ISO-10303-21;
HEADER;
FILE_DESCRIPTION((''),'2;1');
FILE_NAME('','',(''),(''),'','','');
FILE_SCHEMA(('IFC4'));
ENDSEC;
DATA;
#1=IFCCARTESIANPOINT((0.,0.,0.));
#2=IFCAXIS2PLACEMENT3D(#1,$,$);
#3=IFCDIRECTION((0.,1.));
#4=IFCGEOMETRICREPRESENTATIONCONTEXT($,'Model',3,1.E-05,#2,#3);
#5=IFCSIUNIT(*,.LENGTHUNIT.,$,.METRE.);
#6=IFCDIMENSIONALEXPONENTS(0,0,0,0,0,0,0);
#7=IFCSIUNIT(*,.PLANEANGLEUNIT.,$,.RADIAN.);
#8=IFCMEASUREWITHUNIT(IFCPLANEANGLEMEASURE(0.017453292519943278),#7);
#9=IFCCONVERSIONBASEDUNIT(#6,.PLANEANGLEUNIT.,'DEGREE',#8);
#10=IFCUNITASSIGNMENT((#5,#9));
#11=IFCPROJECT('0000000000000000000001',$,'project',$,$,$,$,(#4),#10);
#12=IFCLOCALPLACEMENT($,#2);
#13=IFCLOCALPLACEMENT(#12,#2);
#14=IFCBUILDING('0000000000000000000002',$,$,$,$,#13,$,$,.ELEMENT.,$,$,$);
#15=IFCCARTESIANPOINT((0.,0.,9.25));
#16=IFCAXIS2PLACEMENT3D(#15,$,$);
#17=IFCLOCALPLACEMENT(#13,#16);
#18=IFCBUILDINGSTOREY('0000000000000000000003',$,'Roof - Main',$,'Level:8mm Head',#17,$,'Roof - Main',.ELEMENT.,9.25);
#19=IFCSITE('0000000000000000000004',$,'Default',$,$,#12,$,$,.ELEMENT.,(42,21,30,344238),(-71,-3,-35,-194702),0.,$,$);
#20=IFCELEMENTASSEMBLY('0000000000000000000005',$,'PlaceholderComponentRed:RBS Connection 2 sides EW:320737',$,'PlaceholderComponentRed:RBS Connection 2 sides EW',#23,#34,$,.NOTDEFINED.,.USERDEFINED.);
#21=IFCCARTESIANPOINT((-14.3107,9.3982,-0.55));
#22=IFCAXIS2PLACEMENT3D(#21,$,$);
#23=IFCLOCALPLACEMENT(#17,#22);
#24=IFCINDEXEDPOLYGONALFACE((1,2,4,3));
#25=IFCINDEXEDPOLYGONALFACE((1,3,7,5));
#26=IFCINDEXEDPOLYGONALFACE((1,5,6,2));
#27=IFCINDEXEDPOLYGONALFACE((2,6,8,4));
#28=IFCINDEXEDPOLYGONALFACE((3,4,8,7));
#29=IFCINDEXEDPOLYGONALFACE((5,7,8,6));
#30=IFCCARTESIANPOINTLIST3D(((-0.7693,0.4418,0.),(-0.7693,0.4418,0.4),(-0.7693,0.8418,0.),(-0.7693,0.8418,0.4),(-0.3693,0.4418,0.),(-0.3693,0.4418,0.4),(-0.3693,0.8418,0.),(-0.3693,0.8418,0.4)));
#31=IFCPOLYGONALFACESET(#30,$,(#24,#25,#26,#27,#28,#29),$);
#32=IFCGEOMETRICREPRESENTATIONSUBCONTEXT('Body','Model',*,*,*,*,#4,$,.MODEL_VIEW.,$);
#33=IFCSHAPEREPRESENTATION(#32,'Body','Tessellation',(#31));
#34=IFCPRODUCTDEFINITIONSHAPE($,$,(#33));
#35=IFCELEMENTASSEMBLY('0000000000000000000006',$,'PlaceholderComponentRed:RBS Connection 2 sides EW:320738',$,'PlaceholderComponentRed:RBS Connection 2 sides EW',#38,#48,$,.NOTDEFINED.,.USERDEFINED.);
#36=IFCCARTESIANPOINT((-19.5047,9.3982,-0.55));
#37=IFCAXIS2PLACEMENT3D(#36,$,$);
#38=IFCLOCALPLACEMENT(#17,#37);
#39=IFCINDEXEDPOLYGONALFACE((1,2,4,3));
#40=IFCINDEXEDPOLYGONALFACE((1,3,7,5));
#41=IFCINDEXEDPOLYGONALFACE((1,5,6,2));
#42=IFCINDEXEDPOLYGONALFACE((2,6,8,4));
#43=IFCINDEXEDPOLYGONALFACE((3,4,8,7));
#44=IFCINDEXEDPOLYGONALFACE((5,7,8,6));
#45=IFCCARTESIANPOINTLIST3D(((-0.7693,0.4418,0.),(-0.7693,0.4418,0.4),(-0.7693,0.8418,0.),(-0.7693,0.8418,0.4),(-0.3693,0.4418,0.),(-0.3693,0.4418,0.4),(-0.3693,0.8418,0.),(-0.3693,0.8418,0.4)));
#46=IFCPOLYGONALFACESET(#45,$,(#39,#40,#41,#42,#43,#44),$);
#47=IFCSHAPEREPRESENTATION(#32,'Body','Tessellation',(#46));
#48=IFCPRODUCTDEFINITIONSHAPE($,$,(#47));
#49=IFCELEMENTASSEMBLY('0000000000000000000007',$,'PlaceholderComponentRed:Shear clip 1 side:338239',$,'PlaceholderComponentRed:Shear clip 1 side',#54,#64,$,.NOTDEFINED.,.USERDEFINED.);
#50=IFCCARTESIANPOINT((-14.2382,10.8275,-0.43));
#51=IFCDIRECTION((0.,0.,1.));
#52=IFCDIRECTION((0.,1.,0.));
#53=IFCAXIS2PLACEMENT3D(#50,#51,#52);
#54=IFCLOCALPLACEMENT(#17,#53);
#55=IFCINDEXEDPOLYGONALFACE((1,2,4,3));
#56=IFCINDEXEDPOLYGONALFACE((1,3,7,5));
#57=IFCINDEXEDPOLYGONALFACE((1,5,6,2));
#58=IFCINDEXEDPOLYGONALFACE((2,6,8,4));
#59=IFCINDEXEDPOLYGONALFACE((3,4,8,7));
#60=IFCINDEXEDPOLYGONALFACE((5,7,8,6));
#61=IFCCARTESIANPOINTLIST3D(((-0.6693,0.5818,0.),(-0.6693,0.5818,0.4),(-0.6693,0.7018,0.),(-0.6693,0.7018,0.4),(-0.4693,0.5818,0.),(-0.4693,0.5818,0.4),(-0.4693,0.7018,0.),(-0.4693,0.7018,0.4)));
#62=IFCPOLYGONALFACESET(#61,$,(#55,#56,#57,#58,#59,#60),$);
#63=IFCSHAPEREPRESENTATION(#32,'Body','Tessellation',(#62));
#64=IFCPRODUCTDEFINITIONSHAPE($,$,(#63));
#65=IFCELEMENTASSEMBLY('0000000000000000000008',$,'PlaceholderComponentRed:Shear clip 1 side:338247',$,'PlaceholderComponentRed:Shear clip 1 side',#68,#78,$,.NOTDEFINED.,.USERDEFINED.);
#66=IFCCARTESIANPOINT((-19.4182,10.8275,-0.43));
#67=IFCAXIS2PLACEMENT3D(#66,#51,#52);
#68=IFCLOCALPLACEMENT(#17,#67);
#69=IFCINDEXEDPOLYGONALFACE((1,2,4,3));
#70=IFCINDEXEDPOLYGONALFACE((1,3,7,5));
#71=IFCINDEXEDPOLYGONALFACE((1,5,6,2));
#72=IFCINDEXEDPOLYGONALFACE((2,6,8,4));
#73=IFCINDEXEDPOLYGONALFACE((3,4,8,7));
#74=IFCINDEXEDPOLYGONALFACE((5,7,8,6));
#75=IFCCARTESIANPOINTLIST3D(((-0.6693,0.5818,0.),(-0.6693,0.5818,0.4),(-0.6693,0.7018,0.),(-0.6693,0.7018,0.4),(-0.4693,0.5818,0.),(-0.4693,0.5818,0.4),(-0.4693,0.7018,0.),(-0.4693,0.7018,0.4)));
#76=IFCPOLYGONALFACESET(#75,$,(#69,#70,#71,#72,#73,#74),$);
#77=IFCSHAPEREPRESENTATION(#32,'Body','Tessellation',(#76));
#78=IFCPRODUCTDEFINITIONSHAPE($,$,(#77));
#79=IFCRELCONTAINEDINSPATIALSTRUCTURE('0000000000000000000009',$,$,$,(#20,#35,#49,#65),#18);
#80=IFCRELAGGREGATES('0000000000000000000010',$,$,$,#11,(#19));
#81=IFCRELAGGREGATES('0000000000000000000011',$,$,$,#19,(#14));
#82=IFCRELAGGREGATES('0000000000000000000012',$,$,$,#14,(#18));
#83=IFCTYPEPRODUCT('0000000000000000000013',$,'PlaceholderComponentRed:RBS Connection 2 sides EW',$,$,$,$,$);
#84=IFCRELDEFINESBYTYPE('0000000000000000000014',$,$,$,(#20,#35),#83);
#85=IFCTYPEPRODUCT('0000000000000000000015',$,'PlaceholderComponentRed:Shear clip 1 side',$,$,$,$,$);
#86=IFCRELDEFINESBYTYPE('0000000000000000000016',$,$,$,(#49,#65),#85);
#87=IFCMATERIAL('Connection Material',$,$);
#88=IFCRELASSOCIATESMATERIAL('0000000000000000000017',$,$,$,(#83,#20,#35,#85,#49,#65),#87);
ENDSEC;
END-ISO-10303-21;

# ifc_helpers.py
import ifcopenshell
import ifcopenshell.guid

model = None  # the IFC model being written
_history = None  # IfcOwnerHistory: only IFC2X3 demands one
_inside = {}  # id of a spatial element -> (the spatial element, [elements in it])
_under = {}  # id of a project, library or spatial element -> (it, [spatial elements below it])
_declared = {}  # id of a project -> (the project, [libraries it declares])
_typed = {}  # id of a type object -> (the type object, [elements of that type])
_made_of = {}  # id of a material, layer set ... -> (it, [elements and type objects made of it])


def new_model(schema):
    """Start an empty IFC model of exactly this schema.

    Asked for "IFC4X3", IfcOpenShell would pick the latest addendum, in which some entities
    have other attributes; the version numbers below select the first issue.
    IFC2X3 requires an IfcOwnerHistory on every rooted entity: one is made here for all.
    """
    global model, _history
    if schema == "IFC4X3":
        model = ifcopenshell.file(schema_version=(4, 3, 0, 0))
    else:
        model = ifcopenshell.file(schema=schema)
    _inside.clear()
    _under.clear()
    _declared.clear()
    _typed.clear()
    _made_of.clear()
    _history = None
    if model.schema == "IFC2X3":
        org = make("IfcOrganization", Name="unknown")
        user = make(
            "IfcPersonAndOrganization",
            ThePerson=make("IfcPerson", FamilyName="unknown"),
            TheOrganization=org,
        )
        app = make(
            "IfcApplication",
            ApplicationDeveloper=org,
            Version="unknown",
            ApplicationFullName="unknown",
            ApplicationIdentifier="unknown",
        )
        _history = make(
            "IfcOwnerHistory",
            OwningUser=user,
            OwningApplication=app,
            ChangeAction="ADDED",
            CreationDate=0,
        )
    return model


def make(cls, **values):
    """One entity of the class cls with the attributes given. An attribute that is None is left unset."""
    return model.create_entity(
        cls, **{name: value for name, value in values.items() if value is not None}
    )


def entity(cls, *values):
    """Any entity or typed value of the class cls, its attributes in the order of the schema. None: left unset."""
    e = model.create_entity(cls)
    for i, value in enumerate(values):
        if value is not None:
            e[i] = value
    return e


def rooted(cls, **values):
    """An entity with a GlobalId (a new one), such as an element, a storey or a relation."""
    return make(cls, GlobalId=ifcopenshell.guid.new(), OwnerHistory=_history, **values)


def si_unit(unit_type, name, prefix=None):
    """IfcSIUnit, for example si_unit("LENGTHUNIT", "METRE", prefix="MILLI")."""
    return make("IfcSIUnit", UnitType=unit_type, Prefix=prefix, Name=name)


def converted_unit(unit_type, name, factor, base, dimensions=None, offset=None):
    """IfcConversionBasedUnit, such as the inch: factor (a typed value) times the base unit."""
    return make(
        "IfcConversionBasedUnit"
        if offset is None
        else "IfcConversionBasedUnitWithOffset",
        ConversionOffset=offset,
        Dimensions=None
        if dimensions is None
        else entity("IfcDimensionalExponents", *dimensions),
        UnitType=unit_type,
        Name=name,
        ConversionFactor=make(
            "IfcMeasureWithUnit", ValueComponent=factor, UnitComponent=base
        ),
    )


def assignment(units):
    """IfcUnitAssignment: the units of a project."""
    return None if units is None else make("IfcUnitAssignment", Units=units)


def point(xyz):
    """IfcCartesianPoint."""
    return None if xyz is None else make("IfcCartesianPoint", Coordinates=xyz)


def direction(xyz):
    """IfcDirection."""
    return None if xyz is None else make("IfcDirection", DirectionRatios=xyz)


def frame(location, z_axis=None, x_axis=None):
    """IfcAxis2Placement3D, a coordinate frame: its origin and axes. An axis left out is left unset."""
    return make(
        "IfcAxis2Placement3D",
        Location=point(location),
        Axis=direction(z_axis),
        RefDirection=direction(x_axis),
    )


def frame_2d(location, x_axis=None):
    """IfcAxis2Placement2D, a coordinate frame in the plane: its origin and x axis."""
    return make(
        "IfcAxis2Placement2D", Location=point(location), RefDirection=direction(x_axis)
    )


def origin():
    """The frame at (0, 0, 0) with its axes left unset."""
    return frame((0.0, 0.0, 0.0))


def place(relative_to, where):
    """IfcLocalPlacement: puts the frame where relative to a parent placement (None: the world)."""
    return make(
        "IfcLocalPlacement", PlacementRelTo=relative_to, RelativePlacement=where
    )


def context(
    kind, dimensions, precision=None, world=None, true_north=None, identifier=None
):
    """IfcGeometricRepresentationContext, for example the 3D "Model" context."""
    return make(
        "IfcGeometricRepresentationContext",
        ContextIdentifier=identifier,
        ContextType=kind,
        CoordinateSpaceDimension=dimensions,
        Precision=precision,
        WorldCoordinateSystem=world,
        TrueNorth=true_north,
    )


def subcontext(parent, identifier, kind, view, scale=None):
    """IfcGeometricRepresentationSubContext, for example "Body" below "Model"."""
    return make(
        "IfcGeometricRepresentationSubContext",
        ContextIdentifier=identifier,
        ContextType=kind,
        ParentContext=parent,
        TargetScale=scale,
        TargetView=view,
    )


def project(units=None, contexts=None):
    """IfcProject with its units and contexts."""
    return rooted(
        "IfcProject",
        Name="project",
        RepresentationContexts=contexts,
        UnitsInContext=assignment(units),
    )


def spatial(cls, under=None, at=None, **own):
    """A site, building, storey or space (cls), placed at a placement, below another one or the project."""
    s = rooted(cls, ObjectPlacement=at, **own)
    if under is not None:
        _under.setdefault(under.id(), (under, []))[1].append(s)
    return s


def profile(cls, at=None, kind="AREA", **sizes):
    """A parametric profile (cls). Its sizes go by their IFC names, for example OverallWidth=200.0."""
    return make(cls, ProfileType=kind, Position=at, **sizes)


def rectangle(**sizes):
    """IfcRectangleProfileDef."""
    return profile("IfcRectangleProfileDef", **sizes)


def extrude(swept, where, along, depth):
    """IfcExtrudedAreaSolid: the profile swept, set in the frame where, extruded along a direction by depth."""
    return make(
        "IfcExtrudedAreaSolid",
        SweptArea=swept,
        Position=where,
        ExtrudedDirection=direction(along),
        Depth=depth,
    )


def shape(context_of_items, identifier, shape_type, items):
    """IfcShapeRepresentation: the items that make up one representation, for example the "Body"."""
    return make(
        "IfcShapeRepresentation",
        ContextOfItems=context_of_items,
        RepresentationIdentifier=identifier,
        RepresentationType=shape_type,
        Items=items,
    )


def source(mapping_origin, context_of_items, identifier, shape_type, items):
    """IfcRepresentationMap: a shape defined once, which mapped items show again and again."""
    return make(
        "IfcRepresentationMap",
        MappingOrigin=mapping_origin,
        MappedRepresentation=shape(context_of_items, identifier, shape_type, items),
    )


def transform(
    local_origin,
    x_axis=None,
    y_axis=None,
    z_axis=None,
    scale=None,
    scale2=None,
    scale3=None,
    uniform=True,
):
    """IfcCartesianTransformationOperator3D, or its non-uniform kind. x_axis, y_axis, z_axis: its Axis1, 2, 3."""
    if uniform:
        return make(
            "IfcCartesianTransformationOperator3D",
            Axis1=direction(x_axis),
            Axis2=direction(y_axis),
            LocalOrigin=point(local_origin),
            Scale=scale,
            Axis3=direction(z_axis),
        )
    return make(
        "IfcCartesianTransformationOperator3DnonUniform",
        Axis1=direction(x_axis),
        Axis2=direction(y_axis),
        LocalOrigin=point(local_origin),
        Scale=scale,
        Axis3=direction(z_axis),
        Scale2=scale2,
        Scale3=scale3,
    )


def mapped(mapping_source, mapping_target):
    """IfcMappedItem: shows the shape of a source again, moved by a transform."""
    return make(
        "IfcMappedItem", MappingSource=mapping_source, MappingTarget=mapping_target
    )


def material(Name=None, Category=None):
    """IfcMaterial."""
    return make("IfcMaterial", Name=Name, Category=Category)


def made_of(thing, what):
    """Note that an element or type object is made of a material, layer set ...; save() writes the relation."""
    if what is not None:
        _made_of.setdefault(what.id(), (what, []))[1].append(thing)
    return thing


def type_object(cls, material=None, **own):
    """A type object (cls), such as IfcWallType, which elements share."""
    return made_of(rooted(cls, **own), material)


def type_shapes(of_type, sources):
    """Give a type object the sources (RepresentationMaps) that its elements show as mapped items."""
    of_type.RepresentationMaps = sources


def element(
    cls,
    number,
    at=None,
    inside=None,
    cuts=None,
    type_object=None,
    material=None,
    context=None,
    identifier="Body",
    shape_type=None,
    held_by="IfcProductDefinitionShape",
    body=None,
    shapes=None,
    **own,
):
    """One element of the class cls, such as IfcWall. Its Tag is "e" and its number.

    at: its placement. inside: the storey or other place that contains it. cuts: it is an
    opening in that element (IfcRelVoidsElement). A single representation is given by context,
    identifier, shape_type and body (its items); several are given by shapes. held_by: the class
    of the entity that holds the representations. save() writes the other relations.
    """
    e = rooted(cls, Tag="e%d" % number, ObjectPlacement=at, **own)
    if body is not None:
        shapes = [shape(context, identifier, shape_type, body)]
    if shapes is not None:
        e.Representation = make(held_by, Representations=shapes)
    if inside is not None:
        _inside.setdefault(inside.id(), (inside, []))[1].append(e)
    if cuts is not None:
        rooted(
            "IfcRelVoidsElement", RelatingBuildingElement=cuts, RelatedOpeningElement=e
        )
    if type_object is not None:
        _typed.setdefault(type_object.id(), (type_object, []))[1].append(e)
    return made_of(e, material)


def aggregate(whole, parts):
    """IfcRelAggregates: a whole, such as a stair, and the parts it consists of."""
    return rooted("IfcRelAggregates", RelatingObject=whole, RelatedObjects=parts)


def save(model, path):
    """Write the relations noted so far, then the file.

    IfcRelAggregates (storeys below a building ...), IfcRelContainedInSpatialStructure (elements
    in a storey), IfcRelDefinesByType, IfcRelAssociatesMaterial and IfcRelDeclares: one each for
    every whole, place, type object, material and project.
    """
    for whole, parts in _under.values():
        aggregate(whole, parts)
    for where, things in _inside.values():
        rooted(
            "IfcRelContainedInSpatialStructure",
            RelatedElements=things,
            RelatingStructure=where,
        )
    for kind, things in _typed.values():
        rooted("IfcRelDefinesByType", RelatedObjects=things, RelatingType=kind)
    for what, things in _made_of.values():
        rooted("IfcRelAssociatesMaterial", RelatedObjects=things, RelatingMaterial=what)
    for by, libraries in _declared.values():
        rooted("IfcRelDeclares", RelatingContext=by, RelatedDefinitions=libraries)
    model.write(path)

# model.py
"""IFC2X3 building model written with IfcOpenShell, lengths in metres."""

from ifc_helpers import new_model, entity, si_unit, converted_unit, direction, frame, frame_2d, origin, place, context, subcontext, project, spatial, rectangle, extrude, source, transform, mapped, material, type_object, type_shapes, element, save


model = new_model("IFC2X3")

# Units and contexts
model_context = context("Model", 3, precision=1e-05, world=origin(), true_north=direction((0.0, 1.0)))
body_context = subcontext(model_context, "Body", "Model", "MODEL_VIEW")
ifc_project = project(units=[si_unit("LENGTHUNIT", "METRE"), converted_unit("PLANEANGLEUNIT", "DEGREE", entity("IfcPlaneAngleMeasure", 0.017453292519943278), si_unit("PLANEANGLEUNIT", "RADIAN"), dimensions=[0, 0, 0, 0, 0, 0, 0])], contexts=[model_context])

# Site, building, storey
site_placement = place(None, origin())
site = spatial("IfcSite", under=ifc_project, at=site_placement, Name="Default", CompositionType="ELEMENT", RefLatitude=(42, 21, 30, 344238), RefLongitude=(-71, -3, -35, -194702), RefElevation=0.0)
building_placement = place(site_placement, origin())
building = spatial("IfcBuilding", under=site, at=building_placement, CompositionType="ELEMENT")
storey_placement = place(building_placement, frame((0.0, 0.0, 9.25)))
storey = spatial("IfcBuildingStorey", under=building, at=storey_placement, Name="Roof - Main", ObjectType="Level:8mm Head", LongName="Roof - Main", CompositionType="ELEMENT", Elevation=9.25)

# Element assemblies
ifc_material_1 = material(Name="Connection Material")
type_product_1 = type_object("IfcTypeProduct", Name="PlaceholderComponentRed:RBS Connection 2 sides EW", material=ifc_material_1)
shared_shape_1 = source(origin(), body_context, "Body", "SweptSolid", [
    extrude(rectangle(XDim=0.4, YDim=0.4, at=frame_2d((0.0, 0.0), x_axis=(1.0, 0.0))), frame((-0.5693, 0.6418, 0.0), z_axis=(0.0, 0.0, 1.0), x_axis=(0.0, 1.0, 0.0)), (0.0, 0.0, 1.0), 0.4),
])
type_shapes(type_product_1, [shared_shape_1])
for number, where, name in (
    (1, (-14.3107, 9.3982, -0.55), "PlaceholderComponentRed:RBS Connection 2 sides EW:320737"),
    (2, (-19.5047, 9.3982, -0.55), "PlaceholderComponentRed:RBS Connection 2 sides EW:320738"),
):
    element("IfcElementAssembly", number, at=place(storey_placement, frame(where)), inside=storey, type_object=type_product_1, material=ifc_material_1, Name=name, ObjectType="PlaceholderComponentRed:RBS Connection 2 sides EW", AssemblyPlace="NOTDEFINED", PredefinedType="USERDEFINED", context=body_context, shape_type="MappedRepresentation", body=[
        mapped(shared_shape_1, transform((0.0, 0.0, 0.0), scale=1.0)),
    ])
type_product_2 = type_object("IfcTypeProduct", Name="PlaceholderComponentRed:Shear clip 1 side", material=ifc_material_1)
shared_shape_2 = source(origin(), body_context, "Body", "SweptSolid", [
    extrude(rectangle(XDim=0.12, YDim=0.2, at=frame_2d((0.0, 0.0), x_axis=(1.0, 0.0))), frame((-0.5693, 0.6418, 0.0), z_axis=(0.0, 0.0, 1.0), x_axis=(0.0, 1.0, 0.0)), (0.0, 0.0, 1.0), 0.4),
])
type_shapes(type_product_2, [shared_shape_2])
for number, where, z_axis, x_axis, name in (
    (3, (-14.2382, 10.8275, -0.43), (0.0, 0.0, 1.0), (0.0, 1.0, 0.0), "PlaceholderComponentRed:Shear clip 1 side:338239"),
    (4, (-19.4182, 10.8275, -0.43), (0.0, 0.0, 1.0), (0.0, 1.0, 0.0), "PlaceholderComponentRed:Shear clip 1 side:338247"),
):
    element("IfcElementAssembly", number, at=place(storey_placement, frame(where, z_axis=z_axis, x_axis=x_axis)), inside=storey, type_object=type_product_2, material=ifc_material_1, Name=name, ObjectType="PlaceholderComponentRed:Shear clip 1 side", AssemblyPlace="NOTDEFINED", PredefinedType="USERDEFINED", context=body_context, shape_type="MappedRepresentation", body=[
        mapped(shared_shape_2, transform((0.0, 0.0, 0.0), scale=1.0)),
    ])

save(model, "model.ifc")
